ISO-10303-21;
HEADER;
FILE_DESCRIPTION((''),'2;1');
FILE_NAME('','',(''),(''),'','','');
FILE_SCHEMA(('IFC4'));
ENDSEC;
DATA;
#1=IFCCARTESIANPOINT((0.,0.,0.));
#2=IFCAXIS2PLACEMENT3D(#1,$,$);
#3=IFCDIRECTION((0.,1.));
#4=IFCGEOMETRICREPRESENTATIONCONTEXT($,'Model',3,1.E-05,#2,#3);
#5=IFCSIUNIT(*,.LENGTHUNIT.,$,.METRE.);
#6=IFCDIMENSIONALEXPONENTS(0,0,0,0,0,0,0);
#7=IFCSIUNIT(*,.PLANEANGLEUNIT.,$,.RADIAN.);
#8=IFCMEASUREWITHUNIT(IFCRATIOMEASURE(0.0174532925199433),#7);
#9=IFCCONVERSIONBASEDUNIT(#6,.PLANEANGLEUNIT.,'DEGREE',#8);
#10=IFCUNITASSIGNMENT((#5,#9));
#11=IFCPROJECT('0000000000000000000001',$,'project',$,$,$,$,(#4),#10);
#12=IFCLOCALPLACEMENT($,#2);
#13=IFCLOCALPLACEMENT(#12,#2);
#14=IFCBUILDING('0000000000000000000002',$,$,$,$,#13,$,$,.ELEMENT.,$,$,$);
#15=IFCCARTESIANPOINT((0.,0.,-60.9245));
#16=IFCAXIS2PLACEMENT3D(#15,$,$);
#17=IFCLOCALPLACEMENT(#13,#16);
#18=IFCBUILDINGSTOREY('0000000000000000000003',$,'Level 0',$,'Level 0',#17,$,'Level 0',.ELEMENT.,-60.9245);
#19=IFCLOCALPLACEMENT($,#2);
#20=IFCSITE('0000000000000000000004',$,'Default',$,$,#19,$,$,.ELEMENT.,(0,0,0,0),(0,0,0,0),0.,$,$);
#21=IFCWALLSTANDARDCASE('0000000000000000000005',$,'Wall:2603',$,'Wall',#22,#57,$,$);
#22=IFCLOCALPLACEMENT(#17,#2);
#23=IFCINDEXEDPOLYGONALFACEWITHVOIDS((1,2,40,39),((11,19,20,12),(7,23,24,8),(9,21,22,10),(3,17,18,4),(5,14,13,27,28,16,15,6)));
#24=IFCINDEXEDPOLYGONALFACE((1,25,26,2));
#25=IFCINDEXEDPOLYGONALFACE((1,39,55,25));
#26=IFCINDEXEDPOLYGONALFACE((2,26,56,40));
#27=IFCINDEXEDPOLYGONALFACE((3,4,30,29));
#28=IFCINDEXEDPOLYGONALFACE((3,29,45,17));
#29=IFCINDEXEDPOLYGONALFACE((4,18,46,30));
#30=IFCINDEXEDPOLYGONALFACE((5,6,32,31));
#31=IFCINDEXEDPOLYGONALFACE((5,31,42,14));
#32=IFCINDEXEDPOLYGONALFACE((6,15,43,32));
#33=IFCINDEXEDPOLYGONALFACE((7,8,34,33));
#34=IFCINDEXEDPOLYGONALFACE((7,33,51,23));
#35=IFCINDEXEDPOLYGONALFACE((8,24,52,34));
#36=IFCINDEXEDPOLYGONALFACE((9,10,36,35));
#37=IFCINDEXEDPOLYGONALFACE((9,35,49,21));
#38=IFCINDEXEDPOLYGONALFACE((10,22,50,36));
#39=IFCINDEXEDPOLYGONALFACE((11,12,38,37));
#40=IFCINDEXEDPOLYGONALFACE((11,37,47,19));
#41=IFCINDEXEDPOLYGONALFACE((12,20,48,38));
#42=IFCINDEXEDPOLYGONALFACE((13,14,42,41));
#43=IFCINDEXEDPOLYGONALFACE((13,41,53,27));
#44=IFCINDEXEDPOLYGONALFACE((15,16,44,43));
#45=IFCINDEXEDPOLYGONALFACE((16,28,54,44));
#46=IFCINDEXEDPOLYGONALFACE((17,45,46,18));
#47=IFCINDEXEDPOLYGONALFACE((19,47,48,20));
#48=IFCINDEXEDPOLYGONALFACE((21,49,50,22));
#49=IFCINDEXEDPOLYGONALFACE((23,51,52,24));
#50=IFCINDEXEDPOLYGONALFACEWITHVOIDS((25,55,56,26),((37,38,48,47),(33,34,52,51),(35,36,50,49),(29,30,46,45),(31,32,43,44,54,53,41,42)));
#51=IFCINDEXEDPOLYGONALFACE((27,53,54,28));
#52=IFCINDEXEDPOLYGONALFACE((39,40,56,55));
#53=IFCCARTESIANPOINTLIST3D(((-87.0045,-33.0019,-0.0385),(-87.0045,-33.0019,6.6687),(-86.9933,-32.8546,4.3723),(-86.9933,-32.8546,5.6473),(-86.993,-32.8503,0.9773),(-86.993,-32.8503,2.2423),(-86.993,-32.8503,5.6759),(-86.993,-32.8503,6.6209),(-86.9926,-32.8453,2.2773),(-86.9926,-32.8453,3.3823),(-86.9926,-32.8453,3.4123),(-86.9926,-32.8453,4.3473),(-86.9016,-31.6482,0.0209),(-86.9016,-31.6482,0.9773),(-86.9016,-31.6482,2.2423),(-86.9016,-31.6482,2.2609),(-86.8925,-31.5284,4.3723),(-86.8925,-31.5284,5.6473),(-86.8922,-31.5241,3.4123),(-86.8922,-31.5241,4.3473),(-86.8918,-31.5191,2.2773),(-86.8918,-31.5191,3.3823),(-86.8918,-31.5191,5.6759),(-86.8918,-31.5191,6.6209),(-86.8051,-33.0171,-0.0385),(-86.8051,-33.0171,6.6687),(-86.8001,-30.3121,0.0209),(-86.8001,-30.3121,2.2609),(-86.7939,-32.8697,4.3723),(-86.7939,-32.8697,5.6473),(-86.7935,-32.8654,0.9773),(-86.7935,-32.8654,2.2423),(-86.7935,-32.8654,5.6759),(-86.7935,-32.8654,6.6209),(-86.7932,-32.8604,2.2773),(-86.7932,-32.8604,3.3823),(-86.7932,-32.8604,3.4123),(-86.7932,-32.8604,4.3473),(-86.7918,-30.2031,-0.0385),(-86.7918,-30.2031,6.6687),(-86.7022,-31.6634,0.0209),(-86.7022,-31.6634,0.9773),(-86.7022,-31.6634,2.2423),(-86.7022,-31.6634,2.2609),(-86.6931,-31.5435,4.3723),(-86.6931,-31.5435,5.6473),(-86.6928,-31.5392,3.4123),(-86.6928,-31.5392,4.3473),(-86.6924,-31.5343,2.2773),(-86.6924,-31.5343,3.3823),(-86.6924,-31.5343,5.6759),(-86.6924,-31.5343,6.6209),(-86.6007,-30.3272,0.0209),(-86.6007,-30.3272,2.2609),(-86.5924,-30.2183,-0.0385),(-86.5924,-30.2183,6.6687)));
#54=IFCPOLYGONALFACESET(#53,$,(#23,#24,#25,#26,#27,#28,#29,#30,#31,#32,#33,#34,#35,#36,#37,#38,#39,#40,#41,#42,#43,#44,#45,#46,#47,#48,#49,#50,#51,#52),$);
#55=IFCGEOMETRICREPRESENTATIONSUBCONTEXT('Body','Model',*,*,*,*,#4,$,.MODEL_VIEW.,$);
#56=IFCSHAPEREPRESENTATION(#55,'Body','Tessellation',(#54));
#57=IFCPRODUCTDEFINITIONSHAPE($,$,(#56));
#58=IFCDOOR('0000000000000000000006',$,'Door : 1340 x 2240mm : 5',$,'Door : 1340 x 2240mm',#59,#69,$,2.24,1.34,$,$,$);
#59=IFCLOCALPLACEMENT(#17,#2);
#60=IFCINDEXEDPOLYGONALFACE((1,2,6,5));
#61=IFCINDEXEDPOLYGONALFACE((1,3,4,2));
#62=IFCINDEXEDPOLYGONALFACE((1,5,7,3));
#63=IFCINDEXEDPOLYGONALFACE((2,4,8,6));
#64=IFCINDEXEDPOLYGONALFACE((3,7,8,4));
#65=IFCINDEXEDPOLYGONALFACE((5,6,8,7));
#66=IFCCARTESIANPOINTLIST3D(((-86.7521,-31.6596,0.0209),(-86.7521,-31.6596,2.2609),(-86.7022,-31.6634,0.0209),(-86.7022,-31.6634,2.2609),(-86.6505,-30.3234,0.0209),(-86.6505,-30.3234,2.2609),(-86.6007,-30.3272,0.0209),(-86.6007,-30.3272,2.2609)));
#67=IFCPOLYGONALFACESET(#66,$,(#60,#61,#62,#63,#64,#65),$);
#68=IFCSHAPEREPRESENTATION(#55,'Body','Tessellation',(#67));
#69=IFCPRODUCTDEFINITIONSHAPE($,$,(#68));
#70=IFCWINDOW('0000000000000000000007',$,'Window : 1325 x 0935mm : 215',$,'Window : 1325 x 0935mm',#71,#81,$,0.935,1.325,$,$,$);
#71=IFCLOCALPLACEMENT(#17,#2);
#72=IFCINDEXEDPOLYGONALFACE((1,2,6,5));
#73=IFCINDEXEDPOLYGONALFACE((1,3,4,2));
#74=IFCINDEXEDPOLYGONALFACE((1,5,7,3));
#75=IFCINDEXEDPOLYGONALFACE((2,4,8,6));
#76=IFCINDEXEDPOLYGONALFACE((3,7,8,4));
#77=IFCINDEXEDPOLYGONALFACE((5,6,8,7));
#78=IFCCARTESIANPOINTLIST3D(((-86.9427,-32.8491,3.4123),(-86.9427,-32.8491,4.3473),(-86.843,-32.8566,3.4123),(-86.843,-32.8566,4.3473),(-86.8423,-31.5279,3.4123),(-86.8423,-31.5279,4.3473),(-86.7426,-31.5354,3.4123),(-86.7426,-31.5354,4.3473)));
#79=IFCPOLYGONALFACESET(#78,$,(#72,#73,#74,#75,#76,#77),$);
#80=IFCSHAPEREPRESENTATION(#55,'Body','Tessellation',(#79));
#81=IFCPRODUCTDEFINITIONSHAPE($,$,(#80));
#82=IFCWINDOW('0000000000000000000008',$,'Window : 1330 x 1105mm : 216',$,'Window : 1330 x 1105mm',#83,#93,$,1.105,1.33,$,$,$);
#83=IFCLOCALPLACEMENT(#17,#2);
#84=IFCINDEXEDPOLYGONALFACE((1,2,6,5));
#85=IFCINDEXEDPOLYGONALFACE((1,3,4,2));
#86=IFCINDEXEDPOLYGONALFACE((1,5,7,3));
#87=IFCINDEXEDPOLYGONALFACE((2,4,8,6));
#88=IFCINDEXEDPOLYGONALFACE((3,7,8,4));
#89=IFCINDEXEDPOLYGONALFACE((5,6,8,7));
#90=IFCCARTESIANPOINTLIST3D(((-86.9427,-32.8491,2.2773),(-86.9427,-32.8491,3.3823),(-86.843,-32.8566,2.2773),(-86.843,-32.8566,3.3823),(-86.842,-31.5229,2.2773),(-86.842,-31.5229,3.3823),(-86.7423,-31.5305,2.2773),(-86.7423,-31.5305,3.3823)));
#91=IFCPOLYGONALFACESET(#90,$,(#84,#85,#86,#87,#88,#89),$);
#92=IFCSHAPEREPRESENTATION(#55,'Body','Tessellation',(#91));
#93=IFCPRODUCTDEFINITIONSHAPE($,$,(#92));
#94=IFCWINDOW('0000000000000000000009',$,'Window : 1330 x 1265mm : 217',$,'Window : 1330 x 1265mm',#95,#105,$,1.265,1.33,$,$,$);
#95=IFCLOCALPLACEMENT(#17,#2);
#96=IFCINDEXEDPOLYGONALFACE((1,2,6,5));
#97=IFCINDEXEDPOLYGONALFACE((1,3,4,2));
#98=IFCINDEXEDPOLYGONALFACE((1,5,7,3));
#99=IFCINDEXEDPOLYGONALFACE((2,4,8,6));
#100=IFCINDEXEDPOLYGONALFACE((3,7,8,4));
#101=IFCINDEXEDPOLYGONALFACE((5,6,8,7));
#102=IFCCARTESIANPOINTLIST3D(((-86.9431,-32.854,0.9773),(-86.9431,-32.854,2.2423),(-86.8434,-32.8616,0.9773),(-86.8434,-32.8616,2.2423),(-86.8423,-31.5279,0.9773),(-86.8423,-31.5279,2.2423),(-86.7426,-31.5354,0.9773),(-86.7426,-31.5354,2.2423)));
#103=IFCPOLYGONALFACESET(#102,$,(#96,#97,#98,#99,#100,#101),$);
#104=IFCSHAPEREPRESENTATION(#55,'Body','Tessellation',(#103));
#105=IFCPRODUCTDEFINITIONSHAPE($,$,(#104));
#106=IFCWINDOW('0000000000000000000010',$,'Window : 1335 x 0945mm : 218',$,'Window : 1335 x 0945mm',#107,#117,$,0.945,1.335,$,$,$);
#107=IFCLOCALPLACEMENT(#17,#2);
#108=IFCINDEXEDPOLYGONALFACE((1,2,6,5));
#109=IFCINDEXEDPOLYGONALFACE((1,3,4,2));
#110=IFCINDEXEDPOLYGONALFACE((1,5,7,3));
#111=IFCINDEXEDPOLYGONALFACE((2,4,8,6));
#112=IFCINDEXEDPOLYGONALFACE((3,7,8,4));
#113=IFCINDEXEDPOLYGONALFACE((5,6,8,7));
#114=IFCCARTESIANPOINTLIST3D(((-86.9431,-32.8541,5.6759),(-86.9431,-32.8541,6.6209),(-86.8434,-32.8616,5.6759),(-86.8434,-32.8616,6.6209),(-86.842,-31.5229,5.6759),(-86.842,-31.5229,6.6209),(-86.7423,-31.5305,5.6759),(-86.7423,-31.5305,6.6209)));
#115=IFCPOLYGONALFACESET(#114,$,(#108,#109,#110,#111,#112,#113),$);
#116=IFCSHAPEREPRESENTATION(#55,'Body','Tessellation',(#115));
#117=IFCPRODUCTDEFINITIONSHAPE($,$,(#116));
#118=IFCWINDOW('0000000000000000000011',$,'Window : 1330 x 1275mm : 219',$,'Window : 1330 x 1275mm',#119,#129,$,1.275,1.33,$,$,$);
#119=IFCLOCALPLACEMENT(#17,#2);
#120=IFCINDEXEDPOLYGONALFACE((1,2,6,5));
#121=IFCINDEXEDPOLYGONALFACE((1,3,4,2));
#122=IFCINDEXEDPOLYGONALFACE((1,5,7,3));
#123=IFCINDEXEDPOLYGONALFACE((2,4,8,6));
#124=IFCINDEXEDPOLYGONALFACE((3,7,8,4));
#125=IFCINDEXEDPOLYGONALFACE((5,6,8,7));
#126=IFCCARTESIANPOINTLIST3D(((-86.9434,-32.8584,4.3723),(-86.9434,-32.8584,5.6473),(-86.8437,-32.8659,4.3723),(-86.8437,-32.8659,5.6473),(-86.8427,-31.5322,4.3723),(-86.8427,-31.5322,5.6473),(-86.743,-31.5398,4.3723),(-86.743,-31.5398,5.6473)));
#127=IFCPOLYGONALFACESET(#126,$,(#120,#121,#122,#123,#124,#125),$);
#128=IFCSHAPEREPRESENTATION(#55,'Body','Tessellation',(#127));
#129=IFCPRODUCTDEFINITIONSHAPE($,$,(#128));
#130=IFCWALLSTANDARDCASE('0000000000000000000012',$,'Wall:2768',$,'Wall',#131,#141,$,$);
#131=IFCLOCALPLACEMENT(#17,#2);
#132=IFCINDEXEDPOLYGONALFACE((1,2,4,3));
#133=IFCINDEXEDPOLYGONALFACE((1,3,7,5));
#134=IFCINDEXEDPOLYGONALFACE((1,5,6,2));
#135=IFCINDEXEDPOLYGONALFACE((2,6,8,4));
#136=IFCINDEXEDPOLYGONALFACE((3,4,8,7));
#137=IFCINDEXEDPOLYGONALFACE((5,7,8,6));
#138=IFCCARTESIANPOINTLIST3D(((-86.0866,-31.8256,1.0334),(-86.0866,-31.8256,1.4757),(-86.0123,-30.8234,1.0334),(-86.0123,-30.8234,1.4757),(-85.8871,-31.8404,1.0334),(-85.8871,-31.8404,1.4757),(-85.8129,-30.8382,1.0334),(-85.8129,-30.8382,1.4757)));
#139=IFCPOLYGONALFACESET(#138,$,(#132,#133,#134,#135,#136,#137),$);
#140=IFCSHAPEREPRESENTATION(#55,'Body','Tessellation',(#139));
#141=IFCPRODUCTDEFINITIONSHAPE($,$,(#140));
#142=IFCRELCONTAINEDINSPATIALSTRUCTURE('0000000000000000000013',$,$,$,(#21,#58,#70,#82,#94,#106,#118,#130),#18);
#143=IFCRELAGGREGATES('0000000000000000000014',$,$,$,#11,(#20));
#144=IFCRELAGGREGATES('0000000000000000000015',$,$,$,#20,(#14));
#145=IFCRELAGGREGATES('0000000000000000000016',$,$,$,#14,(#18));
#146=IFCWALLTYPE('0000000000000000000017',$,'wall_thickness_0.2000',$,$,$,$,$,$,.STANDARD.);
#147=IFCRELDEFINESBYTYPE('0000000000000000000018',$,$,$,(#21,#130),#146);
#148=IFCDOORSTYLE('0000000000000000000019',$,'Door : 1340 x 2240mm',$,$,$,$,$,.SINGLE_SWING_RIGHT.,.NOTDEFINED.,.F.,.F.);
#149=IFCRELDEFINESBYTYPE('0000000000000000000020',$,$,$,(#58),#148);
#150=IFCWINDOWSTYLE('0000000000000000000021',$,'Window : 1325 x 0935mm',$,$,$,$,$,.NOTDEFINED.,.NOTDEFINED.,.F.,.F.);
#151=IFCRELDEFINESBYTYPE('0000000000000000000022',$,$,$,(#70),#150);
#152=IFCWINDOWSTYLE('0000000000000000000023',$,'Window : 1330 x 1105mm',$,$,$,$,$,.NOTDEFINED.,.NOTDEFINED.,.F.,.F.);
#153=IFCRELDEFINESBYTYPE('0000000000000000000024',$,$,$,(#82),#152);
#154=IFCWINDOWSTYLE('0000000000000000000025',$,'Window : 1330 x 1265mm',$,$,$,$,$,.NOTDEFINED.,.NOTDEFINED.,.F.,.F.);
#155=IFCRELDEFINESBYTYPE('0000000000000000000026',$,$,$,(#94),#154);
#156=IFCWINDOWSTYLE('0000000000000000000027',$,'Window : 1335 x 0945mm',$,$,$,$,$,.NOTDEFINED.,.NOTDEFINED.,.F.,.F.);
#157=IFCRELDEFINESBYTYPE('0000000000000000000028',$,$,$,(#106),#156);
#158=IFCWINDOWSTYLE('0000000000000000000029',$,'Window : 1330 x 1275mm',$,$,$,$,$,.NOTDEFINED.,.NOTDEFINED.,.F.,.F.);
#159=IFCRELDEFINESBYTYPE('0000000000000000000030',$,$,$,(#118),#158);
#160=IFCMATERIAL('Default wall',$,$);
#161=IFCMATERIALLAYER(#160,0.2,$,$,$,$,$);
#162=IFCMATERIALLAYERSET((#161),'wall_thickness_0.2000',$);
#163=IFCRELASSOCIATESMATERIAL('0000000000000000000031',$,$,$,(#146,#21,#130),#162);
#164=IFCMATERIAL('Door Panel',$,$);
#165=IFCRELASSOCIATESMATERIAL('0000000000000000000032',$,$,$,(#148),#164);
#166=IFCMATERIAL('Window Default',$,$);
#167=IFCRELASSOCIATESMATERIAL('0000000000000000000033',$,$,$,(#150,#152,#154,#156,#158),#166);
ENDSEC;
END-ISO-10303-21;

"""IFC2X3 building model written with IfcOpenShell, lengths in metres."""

from ifc_helpers import new_model, entity, si_unit, converted_unit, direction, frame, frame_2d, origin, origin_2d_with_axis, place, context, subcontext, project, spatial, polyline, rectangle, outline, extrude, source, transform, mapped, material, layer, layer_set, layer_usage, type_object, type_shapes, element, fill, save


model = new_model("IFC2X3")

# Units and contexts
model_context = context("Model", 3, precision=1e-05, world=origin(), true_north=direction((0.0, 1.0)))
body_context = subcontext(model_context, "Body", "Model", "MODEL_VIEW")
ifc_project = project(units=[si_unit("LENGTHUNIT", "METRE"), converted_unit("PLANEANGLEUNIT", "DEGREE", entity("IfcRatioMeasure", 0.0174532925199433), si_unit("PLANEANGLEUNIT", "RADIAN"), dimensions=[0, 0, 0, 0, 0, 0, 0])], contexts=[model_context])

# Site, building, storey
site_placement = place(None, origin())
site = spatial("IfcSite", under=ifc_project, at=site_placement, Name="Default", CompositionType="ELEMENT", RefLatitude=(0, 0, 0, 0), RefLongitude=(0, 0, 0, 0), RefElevation=0.0)
placement_1 = place(None, origin())
building_placement = place(placement_1, origin())
building = spatial("IfcBuilding", under=site, at=building_placement, CompositionType="ELEMENT")
storey_placement = place(building_placement, frame((0.0, 0.0, -60.9245)))
storey = spatial("IfcBuildingStorey", under=building, at=storey_placement, Name="Level 0", ObjectType="Level 0", LongName="Level 0", CompositionType="ELEMENT", Elevation=-60.9245)

# Shared definitions
ifc_material_1 = material(Name="Default wall")
ifc_layer = layer(ifc_material_1, 0.2)
ifc_layer_set = layer_set([ifc_layer], Name="wall_thickness_0.2000")
ifc_layer_usage = layer_usage(ifc_layer_set, "AXIS2", "POSITIVE", -0.1)
wall_type = type_object("IfcWallType", Name="wall_thickness_0.2000", PredefinedType="STANDARD", material=ifc_layer_set)

# Shared definitions
ifc_material_2 = material(Name="Window Default")

# Wall, openings, door, windows
placement_2 = place(building_placement, frame((0.0, 0.0, -60.963)))
wall_1_placement = place(placement_2, frame((-86.6921, -30.2107, 0.0), z_axis=(0.0, 0.0, 1.0), x_axis=(-0.075765, -0.997126, 0.0)))
wall_1 = element("IfcWallStandardCase", 1, at=wall_1_placement, inside=storey, type_object=wall_type, material=ifc_layer_usage, Name="Wall:2603", ObjectType="Wall", context=body_context, shape_type="SweptSolid", body=[
    extrude(outline(polyline([(2.8069, -0.1), (2.8069, 0.1), (0.0, 0.1), (0.0, -0.1), (2.8069, -0.1)])), origin(), (0.0, 0.0, 1.0), 6.7072),
])
opening_1_placement = place(wall_1_placement, frame((0.1093, -0.1, 0.0594)))
opening_1 = element("IfcOpeningElement", 2, at=opening_1_placement, cuts=wall_1, ObjectType="Opening", context=body_context, shape_type="SweptSolid", body=[
    extrude(rectangle(XDim=1.34, YDim=2.24, at=frame_2d((1.12, 0.67), x_axis=(0.0, 1.0))), frame((0.0, 0.0, 0.0), z_axis=(0.0, 1.0, 0.0), x_axis=(0.0, 0.0, 1.0)), (0.0, 0.0, 1.0), 0.2),
])
opening_2_placement = place(wall_1_placement, frame((1.3248, -0.1, 3.4509)))
opening_2 = element("IfcOpeningElement", 3, at=opening_2_placement, cuts=wall_1, ObjectType="Opening", context=body_context, shape_type="SweptSolid", body=[
    extrude(rectangle(XDim=1.325, YDim=0.935, at=frame_2d((0.4675, 0.6625), x_axis=(0.0, 1.0))), frame((0.0, 0.0, 0.0), z_axis=(0.0, 1.0, 0.0), x_axis=(0.0, 0.0, 1.0)), (0.0, 0.0, 1.0), 0.2),
])
opening_3_placement = place(wall_1_placement, frame((1.3198, -0.1, 2.3159)))
opening_3 = element("IfcOpeningElement", 4, at=opening_3_placement, cuts=wall_1, ObjectType="Opening", context=body_context, shape_type="SweptSolid", body=[
    extrude(rectangle(XDim=1.33, YDim=1.105, at=frame_2d((0.5525, 0.665), x_axis=(0.0, 1.0))), frame((0.0, 0.0, 0.0), z_axis=(0.0, 1.0, 0.0), x_axis=(0.0, 0.0, 1.0)), (0.0, 0.0, 1.0), 0.2),
])
opening_4_placement = place(wall_1_placement, frame((1.3248, -0.1, 1.0159)))
opening_4 = element("IfcOpeningElement", 5, at=opening_4_placement, cuts=wall_1, ObjectType="Opening", context=body_context, shape_type="SweptSolid", body=[
    extrude(rectangle(XDim=1.33, YDim=1.265, at=frame_2d((0.6325, 0.665), x_axis=(0.0, 1.0))), frame((0.0, 0.0, 0.0), z_axis=(0.0, 1.0, 0.0), x_axis=(0.0, 0.0, 1.0)), (0.0, 0.0, 1.0), 0.2),
])
opening_5_placement = place(wall_1_placement, frame((1.3198, -0.1, 5.7144)))
opening_5 = element("IfcOpeningElement", 6, at=opening_5_placement, cuts=wall_1, ObjectType="Opening", context=body_context, shape_type="SweptSolid", body=[
    extrude(rectangle(XDim=1.335, YDim=0.945, at=frame_2d((0.4725, 0.6675), x_axis=(0.0, 1.0))), frame((0.0, 0.0, 0.0), z_axis=(0.0, 1.0, 0.0), x_axis=(0.0, 0.0, 1.0)), (0.0, 0.0, 1.0), 0.2),
])
opening_6_placement = place(wall_1_placement, frame((1.3291, -0.1, 4.4109)))
opening_6 = element("IfcOpeningElement", 7, at=opening_6_placement, cuts=wall_1, ObjectType="Opening", context=body_context, shape_type="SweptSolid", body=[
    extrude(rectangle(XDim=1.33, YDim=1.275, at=frame_2d((0.6375, 0.665), x_axis=(0.0, 1.0))), frame((0.0, 0.0, 0.0), z_axis=(0.0, 1.0, 0.0), x_axis=(0.0, 0.0, 1.0)), (0.0, 0.0, 1.0), 0.2),
])
ifc_material_3 = material(Name="Door Panel")
door_style = type_object("IfcDoorStyle", Name="Door : 1340 x 2240mm", ConstructionType="NOTDEFINED", OperationType="SINGLE_SWING_RIGHT", ParameterTakesPrecedence=False, Sizeable=False, material=ifc_material_3)
shared_shape_1 = source(origin(), body_context, "Body", "SweptSolid", [
    extrude(rectangle(XDim=0.05, YDim=1.34, at=origin_2d_with_axis()), frame((0.67, 0.175, 0.0), z_axis=(0.0, 0.0, 1.0), x_axis=(0.0, 1.0, 0.0)), (0.0, 0.0, 1.0), 2.24),
])
type_shapes(door_style, [shared_shape_1])
door_placement = place(opening_1_placement, origin())
door = element("IfcDoor", 8, at=door_placement, inside=storey, type_object=door_style, Name="Door : 1340 x 2240mm : 5", ObjectType="Door : 1340 x 2240mm", OverallHeight=2.24, OverallWidth=1.34, context=body_context, shape_type="MappedRepresentation", body=[
    mapped(shared_shape_1, transform((0.0, 0.0, 0.0), scale=1.0)),
])
fill(opening_1, door)
window_style_1 = type_object("IfcWindowStyle", Name="Window : 1325 x 0935mm", ConstructionType="NOTDEFINED", OperationType="NOTDEFINED", ParameterTakesPrecedence=False, Sizeable=False, material=ifc_material_2)
shared_shape_2 = source(origin(), body_context, "Body", "SweptSolid", [
    extrude(rectangle(XDim=0.1, YDim=1.325, at=origin_2d_with_axis()), frame((0.6625, 0.1, 0.0), z_axis=(0.0, 0.0, 1.0), x_axis=(0.0, 1.0, 0.0)), (0.0, 0.0, 1.0), 0.935),
])
type_shapes(window_style_1, [shared_shape_2])
window_1_placement = place(opening_2_placement, origin())
window_1 = element("IfcWindow", 9, at=window_1_placement, inside=storey, type_object=window_style_1, Name="Window : 1325 x 0935mm : 215", ObjectType="Window : 1325 x 0935mm", OverallHeight=0.935, OverallWidth=1.325, context=body_context, shape_type="MappedRepresentation", body=[
    mapped(shared_shape_2, transform((0.0, 0.0, 0.0), scale=1.0)),
])
fill(opening_2, window_1)
window_style_2 = type_object("IfcWindowStyle", Name="Window : 1330 x 1105mm", ConstructionType="NOTDEFINED", OperationType="NOTDEFINED", ParameterTakesPrecedence=False, Sizeable=False, material=ifc_material_2)
shared_shape_3 = source(origin(), body_context, "Body", "SweptSolid", [
    extrude(rectangle(XDim=0.1, YDim=1.33, at=origin_2d_with_axis()), frame((0.665, 0.1, 0.0), z_axis=(0.0, 0.0, 1.0), x_axis=(0.0, 1.0, 0.0)), (0.0, 0.0, 1.0), 1.105),
])
type_shapes(window_style_2, [shared_shape_3])
window_2_placement = place(opening_3_placement, origin())
window_2 = element("IfcWindow", 10, at=window_2_placement, inside=storey, type_object=window_style_2, Name="Window : 1330 x 1105mm : 216", ObjectType="Window : 1330 x 1105mm", OverallHeight=1.105, OverallWidth=1.33, context=body_context, shape_type="MappedRepresentation", body=[
    mapped(shared_shape_3, transform((0.0, 0.0, 0.0), scale=1.0)),
])
fill(opening_3, window_2)
window_style_3 = type_object("IfcWindowStyle", Name="Window : 1330 x 1265mm", ConstructionType="NOTDEFINED", OperationType="NOTDEFINED", ParameterTakesPrecedence=False, Sizeable=False, material=ifc_material_2)
shared_shape_4 = source(origin(), body_context, "Body", "SweptSolid", [
    extrude(rectangle(XDim=0.1, YDim=1.33, at=origin_2d_with_axis()), frame((0.665, 0.1, 0.0), z_axis=(0.0, 0.0, 1.0), x_axis=(0.0, 1.0, 0.0)), (0.0, 0.0, 1.0), 1.265),
])
type_shapes(window_style_3, [shared_shape_4])
window_3_placement = place(opening_4_placement, origin())
window_3 = element("IfcWindow", 11, at=window_3_placement, inside=storey, type_object=window_style_3, Name="Window : 1330 x 1265mm : 217", ObjectType="Window : 1330 x 1265mm", OverallHeight=1.265, OverallWidth=1.33, context=body_context, shape_type="MappedRepresentation", body=[
    mapped(shared_shape_4, transform((0.0, 0.0, 0.0), scale=1.0)),
])
fill(opening_4, window_3)
window_style_4 = type_object("IfcWindowStyle", Name="Window : 1335 x 0945mm", ConstructionType="NOTDEFINED", OperationType="NOTDEFINED", ParameterTakesPrecedence=False, Sizeable=False, material=ifc_material_2)
shared_shape_5 = source(origin(), body_context, "Body", "SweptSolid", [
    extrude(rectangle(XDim=0.1, YDim=1.335, at=origin_2d_with_axis()), frame((0.6675, 0.1, 0.0), z_axis=(0.0, 0.0, 1.0), x_axis=(0.0, 1.0, 0.0)), (0.0, 0.0, 1.0), 0.945),
])
type_shapes(window_style_4, [shared_shape_5])
window_4_placement = place(opening_5_placement, origin())
window_4 = element("IfcWindow", 12, at=window_4_placement, inside=storey, type_object=window_style_4, Name="Window : 1335 x 0945mm : 218", ObjectType="Window : 1335 x 0945mm", OverallHeight=0.945, OverallWidth=1.335, context=body_context, shape_type="MappedRepresentation", body=[
    mapped(shared_shape_5, transform((0.0, 0.0, 0.0), scale=1.0)),
])
fill(opening_5, window_4)
window_style_5 = type_object("IfcWindowStyle", Name="Window : 1330 x 1275mm", ConstructionType="NOTDEFINED", OperationType="NOTDEFINED", ParameterTakesPrecedence=False, Sizeable=False, material=ifc_material_2)
shared_shape_6 = source(origin(), body_context, "Body", "SweptSolid", [
    extrude(rectangle(XDim=0.1, YDim=1.33, at=origin_2d_with_axis()), frame((0.665, 0.1, 0.0), z_axis=(0.0, 0.0, 1.0), x_axis=(0.0, 1.0, 0.0)), (0.0, 0.0, 1.0), 1.275),
])
type_shapes(window_style_5, [shared_shape_6])
window_5_placement = place(opening_6_placement, origin())
window_5 = element("IfcWindow", 13, at=window_5_placement, inside=storey, type_object=window_style_5, Name="Window : 1330 x 1275mm : 219", ObjectType="Window : 1330 x 1275mm", OverallHeight=1.275, OverallWidth=1.33, context=body_context, shape_type="MappedRepresentation", body=[
    mapped(shared_shape_6, transform((0.0, 0.0, 0.0), scale=1.0)),
])
fill(opening_6, window_5)

# Wall
placement_3 = place(building_placement, frame((0.0, 0.0, -59.8911)))
wall_2_placement = place(placement_3, frame((-85.9126, -30.8308, 0.0), z_axis=(0.0, 0.0, 1.0), x_axis=(-0.073895, -0.997266, 0.0)))
element("IfcWallStandardCase", 14, at=wall_2_placement, inside=storey, type_object=wall_type, material=ifc_layer_usage, Name="Wall:2768", ObjectType="Wall", context=body_context, shape_type="SweptSolid", body=[
    extrude(outline(polyline([(1.005, -0.1), (1.005, 0.1), (0.0, 0.1), (0.0, -0.1), (1.005, -0.1)])), origin(), (0.0, 0.0, 1.0), 0.4423),
])

save(model, "model.ifc")
